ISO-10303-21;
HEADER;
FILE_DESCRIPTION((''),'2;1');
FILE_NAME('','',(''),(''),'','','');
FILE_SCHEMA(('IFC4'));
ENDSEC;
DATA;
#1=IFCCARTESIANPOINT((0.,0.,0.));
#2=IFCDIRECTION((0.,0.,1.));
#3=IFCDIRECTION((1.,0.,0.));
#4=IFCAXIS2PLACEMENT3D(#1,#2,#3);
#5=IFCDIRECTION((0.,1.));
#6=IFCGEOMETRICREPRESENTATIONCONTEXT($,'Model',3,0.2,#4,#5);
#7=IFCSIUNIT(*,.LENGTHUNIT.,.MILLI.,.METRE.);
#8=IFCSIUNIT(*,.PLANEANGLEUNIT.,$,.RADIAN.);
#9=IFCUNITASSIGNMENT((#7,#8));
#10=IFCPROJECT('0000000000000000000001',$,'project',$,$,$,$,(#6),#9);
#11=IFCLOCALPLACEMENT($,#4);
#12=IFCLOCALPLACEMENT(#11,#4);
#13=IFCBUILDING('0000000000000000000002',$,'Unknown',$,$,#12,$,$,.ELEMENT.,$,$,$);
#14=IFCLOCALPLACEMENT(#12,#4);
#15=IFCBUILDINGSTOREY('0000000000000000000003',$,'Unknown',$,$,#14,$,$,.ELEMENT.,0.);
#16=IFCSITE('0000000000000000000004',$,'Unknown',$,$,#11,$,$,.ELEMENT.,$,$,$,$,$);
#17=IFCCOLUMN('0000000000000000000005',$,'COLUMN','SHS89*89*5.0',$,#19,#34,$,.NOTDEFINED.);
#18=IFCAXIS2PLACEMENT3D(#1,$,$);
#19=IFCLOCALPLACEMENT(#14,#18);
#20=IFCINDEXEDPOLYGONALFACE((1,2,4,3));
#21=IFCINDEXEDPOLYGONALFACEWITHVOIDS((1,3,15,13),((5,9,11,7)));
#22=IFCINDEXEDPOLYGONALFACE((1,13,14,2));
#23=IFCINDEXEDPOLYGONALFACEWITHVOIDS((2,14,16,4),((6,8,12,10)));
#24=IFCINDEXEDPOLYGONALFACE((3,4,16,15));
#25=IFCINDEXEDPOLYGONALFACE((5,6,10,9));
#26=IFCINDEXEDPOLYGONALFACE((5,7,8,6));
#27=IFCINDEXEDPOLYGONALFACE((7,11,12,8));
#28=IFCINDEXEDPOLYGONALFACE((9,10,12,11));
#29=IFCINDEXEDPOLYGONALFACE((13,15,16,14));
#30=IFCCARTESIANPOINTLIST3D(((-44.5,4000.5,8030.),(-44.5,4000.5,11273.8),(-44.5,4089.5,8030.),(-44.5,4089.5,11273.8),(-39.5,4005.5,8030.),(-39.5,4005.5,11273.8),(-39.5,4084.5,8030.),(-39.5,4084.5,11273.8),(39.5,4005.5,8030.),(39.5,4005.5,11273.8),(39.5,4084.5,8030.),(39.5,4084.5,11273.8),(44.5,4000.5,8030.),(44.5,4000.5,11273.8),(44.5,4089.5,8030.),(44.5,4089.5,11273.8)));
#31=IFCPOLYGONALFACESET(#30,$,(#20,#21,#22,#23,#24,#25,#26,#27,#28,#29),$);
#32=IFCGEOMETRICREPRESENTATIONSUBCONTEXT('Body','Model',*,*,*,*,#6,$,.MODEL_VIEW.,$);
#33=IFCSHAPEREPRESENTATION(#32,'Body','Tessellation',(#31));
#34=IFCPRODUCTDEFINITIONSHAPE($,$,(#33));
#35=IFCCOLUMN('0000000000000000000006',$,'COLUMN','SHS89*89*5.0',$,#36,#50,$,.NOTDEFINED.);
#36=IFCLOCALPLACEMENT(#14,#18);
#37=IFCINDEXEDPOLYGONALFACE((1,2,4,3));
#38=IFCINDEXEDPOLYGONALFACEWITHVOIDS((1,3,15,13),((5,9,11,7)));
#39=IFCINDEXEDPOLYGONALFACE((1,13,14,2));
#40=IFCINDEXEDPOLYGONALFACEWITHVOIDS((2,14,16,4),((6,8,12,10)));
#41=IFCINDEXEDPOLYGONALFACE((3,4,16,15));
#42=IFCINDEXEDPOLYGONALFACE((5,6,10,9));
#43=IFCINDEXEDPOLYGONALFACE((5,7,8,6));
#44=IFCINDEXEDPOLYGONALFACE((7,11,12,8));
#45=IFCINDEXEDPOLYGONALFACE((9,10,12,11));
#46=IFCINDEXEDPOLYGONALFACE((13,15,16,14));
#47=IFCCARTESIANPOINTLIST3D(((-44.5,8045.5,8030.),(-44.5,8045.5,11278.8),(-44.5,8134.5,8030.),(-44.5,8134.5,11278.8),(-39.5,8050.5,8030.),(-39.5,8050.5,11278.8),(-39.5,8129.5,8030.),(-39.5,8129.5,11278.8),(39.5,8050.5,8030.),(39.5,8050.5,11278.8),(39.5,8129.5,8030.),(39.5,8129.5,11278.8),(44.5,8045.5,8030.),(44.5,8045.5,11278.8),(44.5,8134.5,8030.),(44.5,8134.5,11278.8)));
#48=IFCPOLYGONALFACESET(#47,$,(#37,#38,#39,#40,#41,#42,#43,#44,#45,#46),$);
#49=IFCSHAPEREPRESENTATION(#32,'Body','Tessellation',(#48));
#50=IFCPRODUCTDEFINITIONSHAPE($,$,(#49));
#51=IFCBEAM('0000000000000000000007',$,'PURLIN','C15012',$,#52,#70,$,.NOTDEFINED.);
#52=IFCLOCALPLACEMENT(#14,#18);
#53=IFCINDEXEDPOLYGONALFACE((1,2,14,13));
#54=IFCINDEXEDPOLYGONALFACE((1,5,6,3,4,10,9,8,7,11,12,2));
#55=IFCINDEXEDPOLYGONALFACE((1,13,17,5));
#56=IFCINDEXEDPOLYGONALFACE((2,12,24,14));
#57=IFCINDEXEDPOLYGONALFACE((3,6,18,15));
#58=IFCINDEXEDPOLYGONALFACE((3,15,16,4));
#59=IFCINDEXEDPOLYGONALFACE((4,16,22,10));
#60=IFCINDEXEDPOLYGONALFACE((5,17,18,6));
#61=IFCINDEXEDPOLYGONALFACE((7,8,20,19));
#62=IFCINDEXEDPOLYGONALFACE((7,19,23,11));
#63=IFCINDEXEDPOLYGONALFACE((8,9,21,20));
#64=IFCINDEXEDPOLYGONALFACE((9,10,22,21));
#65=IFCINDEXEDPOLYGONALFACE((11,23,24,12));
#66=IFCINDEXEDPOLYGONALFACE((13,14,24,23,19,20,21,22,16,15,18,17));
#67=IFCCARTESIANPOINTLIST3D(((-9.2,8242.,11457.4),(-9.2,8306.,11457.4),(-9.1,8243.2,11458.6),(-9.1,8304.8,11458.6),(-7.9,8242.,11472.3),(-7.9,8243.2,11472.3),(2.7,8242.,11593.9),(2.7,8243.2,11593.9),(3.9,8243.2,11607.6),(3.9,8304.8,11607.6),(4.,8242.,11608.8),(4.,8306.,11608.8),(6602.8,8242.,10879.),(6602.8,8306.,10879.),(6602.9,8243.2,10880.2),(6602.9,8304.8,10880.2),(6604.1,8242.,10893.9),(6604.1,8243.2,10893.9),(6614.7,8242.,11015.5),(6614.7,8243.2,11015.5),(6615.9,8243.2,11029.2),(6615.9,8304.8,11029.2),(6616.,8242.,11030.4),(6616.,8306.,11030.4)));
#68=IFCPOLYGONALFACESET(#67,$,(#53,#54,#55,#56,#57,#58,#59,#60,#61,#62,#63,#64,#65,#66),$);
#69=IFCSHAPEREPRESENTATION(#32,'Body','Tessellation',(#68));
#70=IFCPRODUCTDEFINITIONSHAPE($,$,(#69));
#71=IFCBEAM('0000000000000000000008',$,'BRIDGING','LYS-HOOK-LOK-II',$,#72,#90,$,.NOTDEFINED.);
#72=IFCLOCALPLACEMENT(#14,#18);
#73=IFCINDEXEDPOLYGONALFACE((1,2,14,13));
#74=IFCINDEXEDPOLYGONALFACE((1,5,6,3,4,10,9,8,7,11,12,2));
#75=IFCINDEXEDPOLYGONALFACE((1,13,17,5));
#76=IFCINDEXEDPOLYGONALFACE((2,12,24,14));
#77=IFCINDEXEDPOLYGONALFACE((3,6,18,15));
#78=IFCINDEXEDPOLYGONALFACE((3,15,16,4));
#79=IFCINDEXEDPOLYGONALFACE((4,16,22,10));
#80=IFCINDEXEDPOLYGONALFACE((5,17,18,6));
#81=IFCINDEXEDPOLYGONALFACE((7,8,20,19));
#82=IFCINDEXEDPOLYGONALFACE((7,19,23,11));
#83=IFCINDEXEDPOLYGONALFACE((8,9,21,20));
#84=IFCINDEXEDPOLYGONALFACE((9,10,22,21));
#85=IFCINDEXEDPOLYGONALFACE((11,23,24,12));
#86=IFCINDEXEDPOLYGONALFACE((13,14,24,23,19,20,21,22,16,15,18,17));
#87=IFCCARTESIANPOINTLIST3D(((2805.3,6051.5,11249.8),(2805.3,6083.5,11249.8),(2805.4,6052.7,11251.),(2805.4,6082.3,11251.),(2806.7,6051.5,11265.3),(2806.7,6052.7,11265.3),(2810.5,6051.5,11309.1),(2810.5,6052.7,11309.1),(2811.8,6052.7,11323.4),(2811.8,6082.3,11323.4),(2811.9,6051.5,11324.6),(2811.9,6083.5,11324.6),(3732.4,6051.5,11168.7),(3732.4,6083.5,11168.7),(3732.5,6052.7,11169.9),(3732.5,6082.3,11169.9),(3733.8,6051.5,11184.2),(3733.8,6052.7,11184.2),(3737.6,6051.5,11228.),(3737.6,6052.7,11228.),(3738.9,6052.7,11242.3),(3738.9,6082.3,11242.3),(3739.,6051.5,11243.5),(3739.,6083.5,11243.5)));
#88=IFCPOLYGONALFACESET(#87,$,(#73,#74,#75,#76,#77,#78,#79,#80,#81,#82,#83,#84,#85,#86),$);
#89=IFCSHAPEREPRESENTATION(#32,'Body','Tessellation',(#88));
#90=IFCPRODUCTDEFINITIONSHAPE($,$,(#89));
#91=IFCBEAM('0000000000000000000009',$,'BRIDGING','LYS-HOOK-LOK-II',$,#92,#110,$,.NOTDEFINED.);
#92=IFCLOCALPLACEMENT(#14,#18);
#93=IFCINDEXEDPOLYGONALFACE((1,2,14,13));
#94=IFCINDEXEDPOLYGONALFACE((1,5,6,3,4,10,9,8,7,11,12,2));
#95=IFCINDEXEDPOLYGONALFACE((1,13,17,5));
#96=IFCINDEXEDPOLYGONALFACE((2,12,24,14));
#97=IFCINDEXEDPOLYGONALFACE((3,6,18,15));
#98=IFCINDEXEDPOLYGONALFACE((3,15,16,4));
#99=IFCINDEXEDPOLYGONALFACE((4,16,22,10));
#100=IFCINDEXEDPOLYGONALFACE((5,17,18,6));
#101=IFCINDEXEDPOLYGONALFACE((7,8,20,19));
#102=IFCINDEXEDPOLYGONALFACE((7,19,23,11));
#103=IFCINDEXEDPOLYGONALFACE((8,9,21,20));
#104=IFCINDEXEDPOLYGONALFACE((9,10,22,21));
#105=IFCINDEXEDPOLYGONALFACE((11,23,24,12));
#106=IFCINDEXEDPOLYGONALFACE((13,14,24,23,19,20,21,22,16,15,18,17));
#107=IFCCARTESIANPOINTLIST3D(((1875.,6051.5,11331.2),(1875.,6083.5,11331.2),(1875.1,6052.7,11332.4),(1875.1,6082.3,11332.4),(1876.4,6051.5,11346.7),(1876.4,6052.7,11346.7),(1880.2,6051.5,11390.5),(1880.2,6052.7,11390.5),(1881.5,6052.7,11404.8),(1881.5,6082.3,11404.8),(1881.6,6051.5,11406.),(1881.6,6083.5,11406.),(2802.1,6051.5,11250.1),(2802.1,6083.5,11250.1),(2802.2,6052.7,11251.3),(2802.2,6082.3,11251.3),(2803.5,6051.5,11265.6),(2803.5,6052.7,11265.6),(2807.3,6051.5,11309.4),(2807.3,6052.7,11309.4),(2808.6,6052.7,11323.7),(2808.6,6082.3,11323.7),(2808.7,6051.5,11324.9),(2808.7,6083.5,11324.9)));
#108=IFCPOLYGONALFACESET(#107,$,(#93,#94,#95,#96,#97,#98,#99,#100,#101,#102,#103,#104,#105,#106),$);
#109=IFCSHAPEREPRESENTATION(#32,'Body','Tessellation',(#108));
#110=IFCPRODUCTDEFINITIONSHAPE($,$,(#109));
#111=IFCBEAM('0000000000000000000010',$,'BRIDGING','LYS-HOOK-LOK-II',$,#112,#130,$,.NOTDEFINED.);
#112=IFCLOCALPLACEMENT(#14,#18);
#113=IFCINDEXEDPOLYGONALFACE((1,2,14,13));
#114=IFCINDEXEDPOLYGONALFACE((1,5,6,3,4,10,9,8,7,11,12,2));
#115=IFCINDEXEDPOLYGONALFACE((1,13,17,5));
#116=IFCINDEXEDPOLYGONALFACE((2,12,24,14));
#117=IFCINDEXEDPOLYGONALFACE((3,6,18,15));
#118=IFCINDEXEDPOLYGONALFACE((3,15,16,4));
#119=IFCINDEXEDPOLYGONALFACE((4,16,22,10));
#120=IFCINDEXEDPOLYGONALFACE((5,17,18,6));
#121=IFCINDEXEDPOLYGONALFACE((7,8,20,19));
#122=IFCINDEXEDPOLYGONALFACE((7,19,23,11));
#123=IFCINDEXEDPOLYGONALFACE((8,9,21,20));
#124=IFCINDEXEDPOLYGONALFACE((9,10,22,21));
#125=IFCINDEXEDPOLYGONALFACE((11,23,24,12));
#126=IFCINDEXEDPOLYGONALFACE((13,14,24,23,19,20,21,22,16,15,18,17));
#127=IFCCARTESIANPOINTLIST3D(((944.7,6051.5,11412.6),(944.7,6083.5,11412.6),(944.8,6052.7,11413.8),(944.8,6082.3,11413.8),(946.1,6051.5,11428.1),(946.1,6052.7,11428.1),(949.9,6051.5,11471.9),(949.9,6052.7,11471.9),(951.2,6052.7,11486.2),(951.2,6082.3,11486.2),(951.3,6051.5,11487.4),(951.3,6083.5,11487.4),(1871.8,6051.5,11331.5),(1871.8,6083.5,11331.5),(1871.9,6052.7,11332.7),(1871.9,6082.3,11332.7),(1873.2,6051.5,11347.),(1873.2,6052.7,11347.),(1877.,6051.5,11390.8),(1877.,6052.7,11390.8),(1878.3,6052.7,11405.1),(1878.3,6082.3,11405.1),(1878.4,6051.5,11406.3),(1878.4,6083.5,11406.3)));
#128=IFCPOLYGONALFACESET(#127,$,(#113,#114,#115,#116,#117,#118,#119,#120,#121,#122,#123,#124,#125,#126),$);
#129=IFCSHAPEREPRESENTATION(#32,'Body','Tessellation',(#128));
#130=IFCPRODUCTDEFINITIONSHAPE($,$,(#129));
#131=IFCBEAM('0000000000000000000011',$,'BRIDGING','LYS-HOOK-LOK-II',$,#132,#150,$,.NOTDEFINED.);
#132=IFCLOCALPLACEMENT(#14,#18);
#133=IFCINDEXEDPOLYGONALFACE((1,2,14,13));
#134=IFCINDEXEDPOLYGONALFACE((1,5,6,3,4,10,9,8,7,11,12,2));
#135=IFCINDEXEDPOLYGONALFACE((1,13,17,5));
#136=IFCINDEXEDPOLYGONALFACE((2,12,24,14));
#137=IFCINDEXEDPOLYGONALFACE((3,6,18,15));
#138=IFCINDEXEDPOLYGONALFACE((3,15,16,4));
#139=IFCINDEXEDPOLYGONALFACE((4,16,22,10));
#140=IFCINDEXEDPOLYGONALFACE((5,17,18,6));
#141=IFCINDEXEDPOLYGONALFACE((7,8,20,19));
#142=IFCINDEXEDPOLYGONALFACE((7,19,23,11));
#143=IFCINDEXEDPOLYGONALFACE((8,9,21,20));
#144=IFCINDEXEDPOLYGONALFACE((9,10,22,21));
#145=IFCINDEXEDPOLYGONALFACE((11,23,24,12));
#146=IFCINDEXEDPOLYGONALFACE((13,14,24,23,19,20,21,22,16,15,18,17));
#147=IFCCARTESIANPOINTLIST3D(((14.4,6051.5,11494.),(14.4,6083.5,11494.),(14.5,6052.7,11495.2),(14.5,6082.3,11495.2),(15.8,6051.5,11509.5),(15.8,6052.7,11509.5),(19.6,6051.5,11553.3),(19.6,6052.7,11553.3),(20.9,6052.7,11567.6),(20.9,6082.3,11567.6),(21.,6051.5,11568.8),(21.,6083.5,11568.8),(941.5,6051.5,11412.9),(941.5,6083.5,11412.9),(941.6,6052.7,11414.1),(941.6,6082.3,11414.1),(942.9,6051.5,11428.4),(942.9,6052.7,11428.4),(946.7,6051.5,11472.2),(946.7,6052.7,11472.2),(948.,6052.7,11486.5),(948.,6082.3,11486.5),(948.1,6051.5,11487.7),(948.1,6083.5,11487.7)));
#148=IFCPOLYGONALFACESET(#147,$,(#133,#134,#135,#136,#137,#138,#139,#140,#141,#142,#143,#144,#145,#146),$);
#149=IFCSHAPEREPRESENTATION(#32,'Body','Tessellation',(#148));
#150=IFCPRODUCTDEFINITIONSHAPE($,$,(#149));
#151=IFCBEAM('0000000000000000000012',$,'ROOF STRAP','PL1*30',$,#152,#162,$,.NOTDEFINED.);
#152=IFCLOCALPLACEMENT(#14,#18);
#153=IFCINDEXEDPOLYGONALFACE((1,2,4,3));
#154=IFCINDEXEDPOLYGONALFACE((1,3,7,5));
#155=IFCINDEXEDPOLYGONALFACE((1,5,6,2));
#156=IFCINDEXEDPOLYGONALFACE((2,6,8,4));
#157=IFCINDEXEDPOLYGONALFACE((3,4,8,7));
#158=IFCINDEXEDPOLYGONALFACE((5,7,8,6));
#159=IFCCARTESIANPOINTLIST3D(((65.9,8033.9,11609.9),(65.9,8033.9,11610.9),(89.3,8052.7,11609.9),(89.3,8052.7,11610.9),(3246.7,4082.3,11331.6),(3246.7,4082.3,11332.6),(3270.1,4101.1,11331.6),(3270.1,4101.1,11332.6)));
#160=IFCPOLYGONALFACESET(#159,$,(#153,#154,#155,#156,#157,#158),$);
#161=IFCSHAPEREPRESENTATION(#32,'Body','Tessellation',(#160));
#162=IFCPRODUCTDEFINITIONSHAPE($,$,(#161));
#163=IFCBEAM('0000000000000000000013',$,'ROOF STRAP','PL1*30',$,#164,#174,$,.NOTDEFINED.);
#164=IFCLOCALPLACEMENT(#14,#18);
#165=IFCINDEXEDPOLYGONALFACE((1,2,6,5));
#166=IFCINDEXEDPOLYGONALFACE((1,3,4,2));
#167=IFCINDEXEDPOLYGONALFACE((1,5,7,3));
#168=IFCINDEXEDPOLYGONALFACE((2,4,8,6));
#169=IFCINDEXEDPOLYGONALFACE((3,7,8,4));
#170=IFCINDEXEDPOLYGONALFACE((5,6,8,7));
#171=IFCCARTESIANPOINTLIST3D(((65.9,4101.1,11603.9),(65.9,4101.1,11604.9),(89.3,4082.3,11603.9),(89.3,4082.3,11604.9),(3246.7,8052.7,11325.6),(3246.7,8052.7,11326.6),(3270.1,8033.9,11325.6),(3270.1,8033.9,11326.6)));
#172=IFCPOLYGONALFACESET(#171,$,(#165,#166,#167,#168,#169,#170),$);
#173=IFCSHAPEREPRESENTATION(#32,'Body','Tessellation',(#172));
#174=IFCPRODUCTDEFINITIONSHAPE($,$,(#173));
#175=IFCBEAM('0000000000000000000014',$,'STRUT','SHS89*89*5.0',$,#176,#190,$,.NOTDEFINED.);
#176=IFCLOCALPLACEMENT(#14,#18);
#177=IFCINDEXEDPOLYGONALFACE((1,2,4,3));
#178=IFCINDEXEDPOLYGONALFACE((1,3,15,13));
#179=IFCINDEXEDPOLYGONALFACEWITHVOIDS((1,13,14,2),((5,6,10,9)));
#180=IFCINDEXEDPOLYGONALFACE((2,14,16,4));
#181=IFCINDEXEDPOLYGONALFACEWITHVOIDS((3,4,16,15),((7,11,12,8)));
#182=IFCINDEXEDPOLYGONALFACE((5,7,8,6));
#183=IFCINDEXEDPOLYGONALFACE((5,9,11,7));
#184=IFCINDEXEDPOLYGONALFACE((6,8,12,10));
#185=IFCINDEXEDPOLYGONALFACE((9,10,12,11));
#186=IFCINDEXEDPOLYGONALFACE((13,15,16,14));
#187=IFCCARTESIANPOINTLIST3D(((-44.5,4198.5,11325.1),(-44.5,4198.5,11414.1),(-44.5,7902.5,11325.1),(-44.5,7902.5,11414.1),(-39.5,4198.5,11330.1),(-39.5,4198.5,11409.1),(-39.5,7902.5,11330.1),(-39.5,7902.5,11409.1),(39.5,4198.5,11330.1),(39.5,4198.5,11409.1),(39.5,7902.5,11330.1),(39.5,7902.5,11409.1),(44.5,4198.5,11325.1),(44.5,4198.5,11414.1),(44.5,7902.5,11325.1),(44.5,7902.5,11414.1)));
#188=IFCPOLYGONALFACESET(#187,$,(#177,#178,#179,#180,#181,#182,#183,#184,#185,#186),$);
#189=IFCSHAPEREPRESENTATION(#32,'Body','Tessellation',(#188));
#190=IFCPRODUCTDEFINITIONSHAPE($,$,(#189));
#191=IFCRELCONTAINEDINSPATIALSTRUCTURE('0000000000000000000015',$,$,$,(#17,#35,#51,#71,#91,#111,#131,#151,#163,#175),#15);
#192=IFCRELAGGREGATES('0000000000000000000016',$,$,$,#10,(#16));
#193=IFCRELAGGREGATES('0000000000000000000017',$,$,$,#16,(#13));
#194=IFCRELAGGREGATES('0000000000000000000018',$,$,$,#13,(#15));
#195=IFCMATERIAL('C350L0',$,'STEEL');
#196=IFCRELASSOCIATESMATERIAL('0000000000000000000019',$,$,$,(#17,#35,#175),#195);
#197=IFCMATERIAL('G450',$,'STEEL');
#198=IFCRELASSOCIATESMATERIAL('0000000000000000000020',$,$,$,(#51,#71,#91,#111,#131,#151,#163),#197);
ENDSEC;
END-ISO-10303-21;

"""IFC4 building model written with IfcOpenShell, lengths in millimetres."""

from ifc_helpers import new_model, si_unit, direction, frame, origin_with_axes, place, context, subcontext, project, spatial, line, indexed_curve, outline, extrude, material, element, save


model = new_model("IFC4")

# Units and contexts
model_context = context("Model", 3, precision=0.2, world=origin_with_axes(), true_north=direction((0.0, 1.0)))
body_context = subcontext(model_context, "Body", "Model", "MODEL_VIEW")
ifc_project = project(units=[si_unit("LENGTHUNIT", "METRE", prefix="MILLI"), si_unit("PLANEANGLEUNIT", "RADIAN")], contexts=[model_context])

# Site, building, storey
site_placement = place(None, origin_with_axes())
site = spatial("IfcSite", under=ifc_project, at=site_placement, Name="Unknown", CompositionType="ELEMENT")
building_placement = place(site_placement, origin_with_axes())
building = spatial("IfcBuilding", under=site, at=building_placement, Name="Unknown", CompositionType="ELEMENT")
storey_placement = place(building_placement, origin_with_axes())
storey = spatial("IfcBuildingStorey", under=building, at=storey_placement, Name="Unknown", CompositionType="ELEMENT", Elevation=0.0)

# Columns
ifc_material_1 = material(Name="C350L0", Category="STEEL")
column_1_placement = place(storey_placement, frame((0.0, 4045.0, 8030.0), z_axis=(-1.0, 0.0, 0.0), x_axis=(0.0, 0.0, 1.0)))
element("IfcColumn", 1, at=column_1_placement, inside=storey, material=ifc_material_1, Name="COLUMN", Description="SHS89*89*5.0", PredefinedType="NOTDEFINED", context=body_context, shape_type="SolidModel", body=[
    extrude(outline(indexed_curve([(-44.5, -44.5), (44.5, -44.5), (44.5, 44.5), (-44.5, 44.5)], segments=[line(1, 2, 3, 4, 1)]), holes=[indexed_curve([(-39.5, -39.5), (-39.5, 39.5), (39.5, 39.5), (39.5, -39.5)], segments=[line(1, 2, 3, 4, 1)])]), frame((0.0, 0.0, 0.0), z_axis=(-1.0, 0.0, 0.0), x_axis=(0.0, 0.0, 1.0)), (0.0, 0.0, -1.0), 3243.8),
])
column_2_placement = place(storey_placement, frame((0.0, 8090.0, 8030.0), z_axis=(-1.0, 0.0, 0.0), x_axis=(0.0, 0.0, 1.0)))
element("IfcColumn", 2, at=column_2_placement, inside=storey, material=ifc_material_1, Name="COLUMN", Description="SHS89*89*5.0", PredefinedType="NOTDEFINED", context=body_context, shape_type="SolidModel", body=[
    extrude(outline(indexed_curve([(-44.5, -44.5), (44.5, -44.5), (44.5, 44.5), (-44.5, 44.5)], segments=[line(1, 2, 3, 4, 1)]), holes=[indexed_curve([(-39.5, -39.5), (-39.5, 39.5), (39.5, 39.5), (39.5, -39.5)], segments=[line(1, 2, 3, 4, 1)])]), frame((0.0, 0.0, 0.0), z_axis=(-1.0, 0.0, 0.0), x_axis=(0.0, 0.0, 1.0)), (0.0, 0.0, -1.0), 3248.8),
])

# Beams
ifc_material_2 = material(Name="G450", Category="STEEL")
beam_1_placement = place(storey_placement, frame((-2.6, 8274.0, 11533.1), z_axis=(0.0, -1.0, 0.0), x_axis=(0.996196, 0.0, -0.087145)))
element("IfcBeam", 3, at=beam_1_placement, inside=storey, material=ifc_material_2, Name="PURLIN", Description="C15012", PredefinedType="NOTDEFINED", context=body_context, shape_type="SolidModel", body=[
    extrude(outline(indexed_curve([(32.0, -76.0), (32.0, -61.0), (30.8, -61.0), (30.8, -74.8), (-30.8, -74.8), (-30.8, 74.8), (30.8, 74.8), (30.8, 61.0), (32.0, 61.0), (32.0, 76.0), (-32.0, 76.0), (-32.0, -76.0)], segments=[line(1, 2, 3, 4, 5, 6, 7, 8, 9, 10, 11, 12, 1)])), frame((0.0, 0.0, 0.0), z_axis=(-1.0, 0.0, 0.0), x_axis=(0.0, 0.0, 1.0)), (0.0, 0.0, -1.0), 6637.3),
])
for number, where, z_axis, x_axis, name in (
    (4, (2808.6, 6067.5, 11287.2), (0.0, -1.0, 0.0), (0.996196, 0.0, -0.087144), "BRIDGING"),
    (5, (1878.3, 6067.5, 11368.6), (0.0, -1.0, 0.0), (0.996196, 0.0, -0.087144), "BRIDGING"),
    (6, (948.0, 6067.5, 11450.0), (0.0, -1.0, 0.0), (0.996196, 0.0, -0.087144), "BRIDGING"),
    (7, (17.7, 6067.5, 11531.4), (0.0, -1.0, 0.0), (0.996196, 0.0, -0.087144), "BRIDGING"),
):
    element("IfcBeam", number, at=place(storey_placement, frame(where, z_axis=z_axis, x_axis=x_axis)), inside=storey, material=ifc_material_2, Name=name, Description="LYS-HOOK-LOK-II", PredefinedType="NOTDEFINED", context=body_context, shape_type="SolidModel", body=[
        extrude(outline(indexed_curve([(16.0, -37.5), (16.0, -22.0), (14.8, -22.0), (14.8, -36.3), (-14.8, -36.3), (-14.8, 36.3), (14.8, 36.3), (14.8, 22.0), (16.0, 22.0), (16.0, 37.5), (-16.0, 37.5), (-16.0, -37.5)], segments=[line(1, 2, 3, 4, 5, 6, 7, 8, 9, 10, 11, 12, 1)])), frame((0.0, 0.0, 0.0), z_axis=(-1.0, 0.0, 0.0), x_axis=(0.0, 0.0, 1.0)), (0.0, 0.0, -1.0), 930.6),
    ])
for number, where, z_axis, x_axis, name in (
    (8, (3258.4, 4091.7, 11332.1), (0.034349, -0.042673, 0.998498), (-0.626097, 0.777819, 0.05478), "ROOF STRAP"),
    (9, (77.6, 4091.7, 11604.4), (0.034349, 0.042673, 0.998498), (0.626097, 0.777819, -0.05478), "ROOF STRAP"),
):
    element("IfcBeam", number, at=place(storey_placement, frame(where, z_axis=z_axis, x_axis=x_axis)), inside=storey, material=ifc_material_2, Name=name, Description="PL1*30", PredefinedType="NOTDEFINED", context=body_context, shape_type="SolidModel", body=[
        extrude(outline(indexed_curve([(-0.5, -15.0), (0.5, -15.0), (0.5, 15.0), (-0.5, 15.0)], segments=[line(1, 2, 3, 4, 1)])), frame((0.0, 0.0, 0.0), z_axis=(-1.0, 0.0, 0.0), x_axis=(0.0, 0.0, 1.0)), (0.0, 0.0, -1.0), 5080.4),
    ])
beam_2_placement = place(storey_placement, frame((0.0, 4198.5, 11369.6), z_axis=(0.0, 0.0, 1.0), x_axis=(0.0, 1.0, 0.0)))
element("IfcBeam", 10, at=beam_2_placement, inside=storey, material=ifc_material_1, Name="STRUT", Description="SHS89*89*5.0", PredefinedType="NOTDEFINED", context=body_context, shape_type="SolidModel", body=[
    extrude(outline(indexed_curve([(-44.5, -44.5), (44.5, -44.5), (44.5, 44.5), (-44.5, 44.5)], segments=[line(1, 2, 3, 4, 1)]), holes=[indexed_curve([(-39.5, -39.5), (-39.5, 39.5), (39.5, 39.5), (39.5, -39.5)], segments=[line(1, 2, 3, 4, 1)])]), frame((0.0, 0.0, 0.0), z_axis=(-1.0, 0.0, 0.0), x_axis=(0.0, 0.0, 1.0)), (0.0, 0.0, -1.0), 3704.0),
])

save(model, "model.ifc")
